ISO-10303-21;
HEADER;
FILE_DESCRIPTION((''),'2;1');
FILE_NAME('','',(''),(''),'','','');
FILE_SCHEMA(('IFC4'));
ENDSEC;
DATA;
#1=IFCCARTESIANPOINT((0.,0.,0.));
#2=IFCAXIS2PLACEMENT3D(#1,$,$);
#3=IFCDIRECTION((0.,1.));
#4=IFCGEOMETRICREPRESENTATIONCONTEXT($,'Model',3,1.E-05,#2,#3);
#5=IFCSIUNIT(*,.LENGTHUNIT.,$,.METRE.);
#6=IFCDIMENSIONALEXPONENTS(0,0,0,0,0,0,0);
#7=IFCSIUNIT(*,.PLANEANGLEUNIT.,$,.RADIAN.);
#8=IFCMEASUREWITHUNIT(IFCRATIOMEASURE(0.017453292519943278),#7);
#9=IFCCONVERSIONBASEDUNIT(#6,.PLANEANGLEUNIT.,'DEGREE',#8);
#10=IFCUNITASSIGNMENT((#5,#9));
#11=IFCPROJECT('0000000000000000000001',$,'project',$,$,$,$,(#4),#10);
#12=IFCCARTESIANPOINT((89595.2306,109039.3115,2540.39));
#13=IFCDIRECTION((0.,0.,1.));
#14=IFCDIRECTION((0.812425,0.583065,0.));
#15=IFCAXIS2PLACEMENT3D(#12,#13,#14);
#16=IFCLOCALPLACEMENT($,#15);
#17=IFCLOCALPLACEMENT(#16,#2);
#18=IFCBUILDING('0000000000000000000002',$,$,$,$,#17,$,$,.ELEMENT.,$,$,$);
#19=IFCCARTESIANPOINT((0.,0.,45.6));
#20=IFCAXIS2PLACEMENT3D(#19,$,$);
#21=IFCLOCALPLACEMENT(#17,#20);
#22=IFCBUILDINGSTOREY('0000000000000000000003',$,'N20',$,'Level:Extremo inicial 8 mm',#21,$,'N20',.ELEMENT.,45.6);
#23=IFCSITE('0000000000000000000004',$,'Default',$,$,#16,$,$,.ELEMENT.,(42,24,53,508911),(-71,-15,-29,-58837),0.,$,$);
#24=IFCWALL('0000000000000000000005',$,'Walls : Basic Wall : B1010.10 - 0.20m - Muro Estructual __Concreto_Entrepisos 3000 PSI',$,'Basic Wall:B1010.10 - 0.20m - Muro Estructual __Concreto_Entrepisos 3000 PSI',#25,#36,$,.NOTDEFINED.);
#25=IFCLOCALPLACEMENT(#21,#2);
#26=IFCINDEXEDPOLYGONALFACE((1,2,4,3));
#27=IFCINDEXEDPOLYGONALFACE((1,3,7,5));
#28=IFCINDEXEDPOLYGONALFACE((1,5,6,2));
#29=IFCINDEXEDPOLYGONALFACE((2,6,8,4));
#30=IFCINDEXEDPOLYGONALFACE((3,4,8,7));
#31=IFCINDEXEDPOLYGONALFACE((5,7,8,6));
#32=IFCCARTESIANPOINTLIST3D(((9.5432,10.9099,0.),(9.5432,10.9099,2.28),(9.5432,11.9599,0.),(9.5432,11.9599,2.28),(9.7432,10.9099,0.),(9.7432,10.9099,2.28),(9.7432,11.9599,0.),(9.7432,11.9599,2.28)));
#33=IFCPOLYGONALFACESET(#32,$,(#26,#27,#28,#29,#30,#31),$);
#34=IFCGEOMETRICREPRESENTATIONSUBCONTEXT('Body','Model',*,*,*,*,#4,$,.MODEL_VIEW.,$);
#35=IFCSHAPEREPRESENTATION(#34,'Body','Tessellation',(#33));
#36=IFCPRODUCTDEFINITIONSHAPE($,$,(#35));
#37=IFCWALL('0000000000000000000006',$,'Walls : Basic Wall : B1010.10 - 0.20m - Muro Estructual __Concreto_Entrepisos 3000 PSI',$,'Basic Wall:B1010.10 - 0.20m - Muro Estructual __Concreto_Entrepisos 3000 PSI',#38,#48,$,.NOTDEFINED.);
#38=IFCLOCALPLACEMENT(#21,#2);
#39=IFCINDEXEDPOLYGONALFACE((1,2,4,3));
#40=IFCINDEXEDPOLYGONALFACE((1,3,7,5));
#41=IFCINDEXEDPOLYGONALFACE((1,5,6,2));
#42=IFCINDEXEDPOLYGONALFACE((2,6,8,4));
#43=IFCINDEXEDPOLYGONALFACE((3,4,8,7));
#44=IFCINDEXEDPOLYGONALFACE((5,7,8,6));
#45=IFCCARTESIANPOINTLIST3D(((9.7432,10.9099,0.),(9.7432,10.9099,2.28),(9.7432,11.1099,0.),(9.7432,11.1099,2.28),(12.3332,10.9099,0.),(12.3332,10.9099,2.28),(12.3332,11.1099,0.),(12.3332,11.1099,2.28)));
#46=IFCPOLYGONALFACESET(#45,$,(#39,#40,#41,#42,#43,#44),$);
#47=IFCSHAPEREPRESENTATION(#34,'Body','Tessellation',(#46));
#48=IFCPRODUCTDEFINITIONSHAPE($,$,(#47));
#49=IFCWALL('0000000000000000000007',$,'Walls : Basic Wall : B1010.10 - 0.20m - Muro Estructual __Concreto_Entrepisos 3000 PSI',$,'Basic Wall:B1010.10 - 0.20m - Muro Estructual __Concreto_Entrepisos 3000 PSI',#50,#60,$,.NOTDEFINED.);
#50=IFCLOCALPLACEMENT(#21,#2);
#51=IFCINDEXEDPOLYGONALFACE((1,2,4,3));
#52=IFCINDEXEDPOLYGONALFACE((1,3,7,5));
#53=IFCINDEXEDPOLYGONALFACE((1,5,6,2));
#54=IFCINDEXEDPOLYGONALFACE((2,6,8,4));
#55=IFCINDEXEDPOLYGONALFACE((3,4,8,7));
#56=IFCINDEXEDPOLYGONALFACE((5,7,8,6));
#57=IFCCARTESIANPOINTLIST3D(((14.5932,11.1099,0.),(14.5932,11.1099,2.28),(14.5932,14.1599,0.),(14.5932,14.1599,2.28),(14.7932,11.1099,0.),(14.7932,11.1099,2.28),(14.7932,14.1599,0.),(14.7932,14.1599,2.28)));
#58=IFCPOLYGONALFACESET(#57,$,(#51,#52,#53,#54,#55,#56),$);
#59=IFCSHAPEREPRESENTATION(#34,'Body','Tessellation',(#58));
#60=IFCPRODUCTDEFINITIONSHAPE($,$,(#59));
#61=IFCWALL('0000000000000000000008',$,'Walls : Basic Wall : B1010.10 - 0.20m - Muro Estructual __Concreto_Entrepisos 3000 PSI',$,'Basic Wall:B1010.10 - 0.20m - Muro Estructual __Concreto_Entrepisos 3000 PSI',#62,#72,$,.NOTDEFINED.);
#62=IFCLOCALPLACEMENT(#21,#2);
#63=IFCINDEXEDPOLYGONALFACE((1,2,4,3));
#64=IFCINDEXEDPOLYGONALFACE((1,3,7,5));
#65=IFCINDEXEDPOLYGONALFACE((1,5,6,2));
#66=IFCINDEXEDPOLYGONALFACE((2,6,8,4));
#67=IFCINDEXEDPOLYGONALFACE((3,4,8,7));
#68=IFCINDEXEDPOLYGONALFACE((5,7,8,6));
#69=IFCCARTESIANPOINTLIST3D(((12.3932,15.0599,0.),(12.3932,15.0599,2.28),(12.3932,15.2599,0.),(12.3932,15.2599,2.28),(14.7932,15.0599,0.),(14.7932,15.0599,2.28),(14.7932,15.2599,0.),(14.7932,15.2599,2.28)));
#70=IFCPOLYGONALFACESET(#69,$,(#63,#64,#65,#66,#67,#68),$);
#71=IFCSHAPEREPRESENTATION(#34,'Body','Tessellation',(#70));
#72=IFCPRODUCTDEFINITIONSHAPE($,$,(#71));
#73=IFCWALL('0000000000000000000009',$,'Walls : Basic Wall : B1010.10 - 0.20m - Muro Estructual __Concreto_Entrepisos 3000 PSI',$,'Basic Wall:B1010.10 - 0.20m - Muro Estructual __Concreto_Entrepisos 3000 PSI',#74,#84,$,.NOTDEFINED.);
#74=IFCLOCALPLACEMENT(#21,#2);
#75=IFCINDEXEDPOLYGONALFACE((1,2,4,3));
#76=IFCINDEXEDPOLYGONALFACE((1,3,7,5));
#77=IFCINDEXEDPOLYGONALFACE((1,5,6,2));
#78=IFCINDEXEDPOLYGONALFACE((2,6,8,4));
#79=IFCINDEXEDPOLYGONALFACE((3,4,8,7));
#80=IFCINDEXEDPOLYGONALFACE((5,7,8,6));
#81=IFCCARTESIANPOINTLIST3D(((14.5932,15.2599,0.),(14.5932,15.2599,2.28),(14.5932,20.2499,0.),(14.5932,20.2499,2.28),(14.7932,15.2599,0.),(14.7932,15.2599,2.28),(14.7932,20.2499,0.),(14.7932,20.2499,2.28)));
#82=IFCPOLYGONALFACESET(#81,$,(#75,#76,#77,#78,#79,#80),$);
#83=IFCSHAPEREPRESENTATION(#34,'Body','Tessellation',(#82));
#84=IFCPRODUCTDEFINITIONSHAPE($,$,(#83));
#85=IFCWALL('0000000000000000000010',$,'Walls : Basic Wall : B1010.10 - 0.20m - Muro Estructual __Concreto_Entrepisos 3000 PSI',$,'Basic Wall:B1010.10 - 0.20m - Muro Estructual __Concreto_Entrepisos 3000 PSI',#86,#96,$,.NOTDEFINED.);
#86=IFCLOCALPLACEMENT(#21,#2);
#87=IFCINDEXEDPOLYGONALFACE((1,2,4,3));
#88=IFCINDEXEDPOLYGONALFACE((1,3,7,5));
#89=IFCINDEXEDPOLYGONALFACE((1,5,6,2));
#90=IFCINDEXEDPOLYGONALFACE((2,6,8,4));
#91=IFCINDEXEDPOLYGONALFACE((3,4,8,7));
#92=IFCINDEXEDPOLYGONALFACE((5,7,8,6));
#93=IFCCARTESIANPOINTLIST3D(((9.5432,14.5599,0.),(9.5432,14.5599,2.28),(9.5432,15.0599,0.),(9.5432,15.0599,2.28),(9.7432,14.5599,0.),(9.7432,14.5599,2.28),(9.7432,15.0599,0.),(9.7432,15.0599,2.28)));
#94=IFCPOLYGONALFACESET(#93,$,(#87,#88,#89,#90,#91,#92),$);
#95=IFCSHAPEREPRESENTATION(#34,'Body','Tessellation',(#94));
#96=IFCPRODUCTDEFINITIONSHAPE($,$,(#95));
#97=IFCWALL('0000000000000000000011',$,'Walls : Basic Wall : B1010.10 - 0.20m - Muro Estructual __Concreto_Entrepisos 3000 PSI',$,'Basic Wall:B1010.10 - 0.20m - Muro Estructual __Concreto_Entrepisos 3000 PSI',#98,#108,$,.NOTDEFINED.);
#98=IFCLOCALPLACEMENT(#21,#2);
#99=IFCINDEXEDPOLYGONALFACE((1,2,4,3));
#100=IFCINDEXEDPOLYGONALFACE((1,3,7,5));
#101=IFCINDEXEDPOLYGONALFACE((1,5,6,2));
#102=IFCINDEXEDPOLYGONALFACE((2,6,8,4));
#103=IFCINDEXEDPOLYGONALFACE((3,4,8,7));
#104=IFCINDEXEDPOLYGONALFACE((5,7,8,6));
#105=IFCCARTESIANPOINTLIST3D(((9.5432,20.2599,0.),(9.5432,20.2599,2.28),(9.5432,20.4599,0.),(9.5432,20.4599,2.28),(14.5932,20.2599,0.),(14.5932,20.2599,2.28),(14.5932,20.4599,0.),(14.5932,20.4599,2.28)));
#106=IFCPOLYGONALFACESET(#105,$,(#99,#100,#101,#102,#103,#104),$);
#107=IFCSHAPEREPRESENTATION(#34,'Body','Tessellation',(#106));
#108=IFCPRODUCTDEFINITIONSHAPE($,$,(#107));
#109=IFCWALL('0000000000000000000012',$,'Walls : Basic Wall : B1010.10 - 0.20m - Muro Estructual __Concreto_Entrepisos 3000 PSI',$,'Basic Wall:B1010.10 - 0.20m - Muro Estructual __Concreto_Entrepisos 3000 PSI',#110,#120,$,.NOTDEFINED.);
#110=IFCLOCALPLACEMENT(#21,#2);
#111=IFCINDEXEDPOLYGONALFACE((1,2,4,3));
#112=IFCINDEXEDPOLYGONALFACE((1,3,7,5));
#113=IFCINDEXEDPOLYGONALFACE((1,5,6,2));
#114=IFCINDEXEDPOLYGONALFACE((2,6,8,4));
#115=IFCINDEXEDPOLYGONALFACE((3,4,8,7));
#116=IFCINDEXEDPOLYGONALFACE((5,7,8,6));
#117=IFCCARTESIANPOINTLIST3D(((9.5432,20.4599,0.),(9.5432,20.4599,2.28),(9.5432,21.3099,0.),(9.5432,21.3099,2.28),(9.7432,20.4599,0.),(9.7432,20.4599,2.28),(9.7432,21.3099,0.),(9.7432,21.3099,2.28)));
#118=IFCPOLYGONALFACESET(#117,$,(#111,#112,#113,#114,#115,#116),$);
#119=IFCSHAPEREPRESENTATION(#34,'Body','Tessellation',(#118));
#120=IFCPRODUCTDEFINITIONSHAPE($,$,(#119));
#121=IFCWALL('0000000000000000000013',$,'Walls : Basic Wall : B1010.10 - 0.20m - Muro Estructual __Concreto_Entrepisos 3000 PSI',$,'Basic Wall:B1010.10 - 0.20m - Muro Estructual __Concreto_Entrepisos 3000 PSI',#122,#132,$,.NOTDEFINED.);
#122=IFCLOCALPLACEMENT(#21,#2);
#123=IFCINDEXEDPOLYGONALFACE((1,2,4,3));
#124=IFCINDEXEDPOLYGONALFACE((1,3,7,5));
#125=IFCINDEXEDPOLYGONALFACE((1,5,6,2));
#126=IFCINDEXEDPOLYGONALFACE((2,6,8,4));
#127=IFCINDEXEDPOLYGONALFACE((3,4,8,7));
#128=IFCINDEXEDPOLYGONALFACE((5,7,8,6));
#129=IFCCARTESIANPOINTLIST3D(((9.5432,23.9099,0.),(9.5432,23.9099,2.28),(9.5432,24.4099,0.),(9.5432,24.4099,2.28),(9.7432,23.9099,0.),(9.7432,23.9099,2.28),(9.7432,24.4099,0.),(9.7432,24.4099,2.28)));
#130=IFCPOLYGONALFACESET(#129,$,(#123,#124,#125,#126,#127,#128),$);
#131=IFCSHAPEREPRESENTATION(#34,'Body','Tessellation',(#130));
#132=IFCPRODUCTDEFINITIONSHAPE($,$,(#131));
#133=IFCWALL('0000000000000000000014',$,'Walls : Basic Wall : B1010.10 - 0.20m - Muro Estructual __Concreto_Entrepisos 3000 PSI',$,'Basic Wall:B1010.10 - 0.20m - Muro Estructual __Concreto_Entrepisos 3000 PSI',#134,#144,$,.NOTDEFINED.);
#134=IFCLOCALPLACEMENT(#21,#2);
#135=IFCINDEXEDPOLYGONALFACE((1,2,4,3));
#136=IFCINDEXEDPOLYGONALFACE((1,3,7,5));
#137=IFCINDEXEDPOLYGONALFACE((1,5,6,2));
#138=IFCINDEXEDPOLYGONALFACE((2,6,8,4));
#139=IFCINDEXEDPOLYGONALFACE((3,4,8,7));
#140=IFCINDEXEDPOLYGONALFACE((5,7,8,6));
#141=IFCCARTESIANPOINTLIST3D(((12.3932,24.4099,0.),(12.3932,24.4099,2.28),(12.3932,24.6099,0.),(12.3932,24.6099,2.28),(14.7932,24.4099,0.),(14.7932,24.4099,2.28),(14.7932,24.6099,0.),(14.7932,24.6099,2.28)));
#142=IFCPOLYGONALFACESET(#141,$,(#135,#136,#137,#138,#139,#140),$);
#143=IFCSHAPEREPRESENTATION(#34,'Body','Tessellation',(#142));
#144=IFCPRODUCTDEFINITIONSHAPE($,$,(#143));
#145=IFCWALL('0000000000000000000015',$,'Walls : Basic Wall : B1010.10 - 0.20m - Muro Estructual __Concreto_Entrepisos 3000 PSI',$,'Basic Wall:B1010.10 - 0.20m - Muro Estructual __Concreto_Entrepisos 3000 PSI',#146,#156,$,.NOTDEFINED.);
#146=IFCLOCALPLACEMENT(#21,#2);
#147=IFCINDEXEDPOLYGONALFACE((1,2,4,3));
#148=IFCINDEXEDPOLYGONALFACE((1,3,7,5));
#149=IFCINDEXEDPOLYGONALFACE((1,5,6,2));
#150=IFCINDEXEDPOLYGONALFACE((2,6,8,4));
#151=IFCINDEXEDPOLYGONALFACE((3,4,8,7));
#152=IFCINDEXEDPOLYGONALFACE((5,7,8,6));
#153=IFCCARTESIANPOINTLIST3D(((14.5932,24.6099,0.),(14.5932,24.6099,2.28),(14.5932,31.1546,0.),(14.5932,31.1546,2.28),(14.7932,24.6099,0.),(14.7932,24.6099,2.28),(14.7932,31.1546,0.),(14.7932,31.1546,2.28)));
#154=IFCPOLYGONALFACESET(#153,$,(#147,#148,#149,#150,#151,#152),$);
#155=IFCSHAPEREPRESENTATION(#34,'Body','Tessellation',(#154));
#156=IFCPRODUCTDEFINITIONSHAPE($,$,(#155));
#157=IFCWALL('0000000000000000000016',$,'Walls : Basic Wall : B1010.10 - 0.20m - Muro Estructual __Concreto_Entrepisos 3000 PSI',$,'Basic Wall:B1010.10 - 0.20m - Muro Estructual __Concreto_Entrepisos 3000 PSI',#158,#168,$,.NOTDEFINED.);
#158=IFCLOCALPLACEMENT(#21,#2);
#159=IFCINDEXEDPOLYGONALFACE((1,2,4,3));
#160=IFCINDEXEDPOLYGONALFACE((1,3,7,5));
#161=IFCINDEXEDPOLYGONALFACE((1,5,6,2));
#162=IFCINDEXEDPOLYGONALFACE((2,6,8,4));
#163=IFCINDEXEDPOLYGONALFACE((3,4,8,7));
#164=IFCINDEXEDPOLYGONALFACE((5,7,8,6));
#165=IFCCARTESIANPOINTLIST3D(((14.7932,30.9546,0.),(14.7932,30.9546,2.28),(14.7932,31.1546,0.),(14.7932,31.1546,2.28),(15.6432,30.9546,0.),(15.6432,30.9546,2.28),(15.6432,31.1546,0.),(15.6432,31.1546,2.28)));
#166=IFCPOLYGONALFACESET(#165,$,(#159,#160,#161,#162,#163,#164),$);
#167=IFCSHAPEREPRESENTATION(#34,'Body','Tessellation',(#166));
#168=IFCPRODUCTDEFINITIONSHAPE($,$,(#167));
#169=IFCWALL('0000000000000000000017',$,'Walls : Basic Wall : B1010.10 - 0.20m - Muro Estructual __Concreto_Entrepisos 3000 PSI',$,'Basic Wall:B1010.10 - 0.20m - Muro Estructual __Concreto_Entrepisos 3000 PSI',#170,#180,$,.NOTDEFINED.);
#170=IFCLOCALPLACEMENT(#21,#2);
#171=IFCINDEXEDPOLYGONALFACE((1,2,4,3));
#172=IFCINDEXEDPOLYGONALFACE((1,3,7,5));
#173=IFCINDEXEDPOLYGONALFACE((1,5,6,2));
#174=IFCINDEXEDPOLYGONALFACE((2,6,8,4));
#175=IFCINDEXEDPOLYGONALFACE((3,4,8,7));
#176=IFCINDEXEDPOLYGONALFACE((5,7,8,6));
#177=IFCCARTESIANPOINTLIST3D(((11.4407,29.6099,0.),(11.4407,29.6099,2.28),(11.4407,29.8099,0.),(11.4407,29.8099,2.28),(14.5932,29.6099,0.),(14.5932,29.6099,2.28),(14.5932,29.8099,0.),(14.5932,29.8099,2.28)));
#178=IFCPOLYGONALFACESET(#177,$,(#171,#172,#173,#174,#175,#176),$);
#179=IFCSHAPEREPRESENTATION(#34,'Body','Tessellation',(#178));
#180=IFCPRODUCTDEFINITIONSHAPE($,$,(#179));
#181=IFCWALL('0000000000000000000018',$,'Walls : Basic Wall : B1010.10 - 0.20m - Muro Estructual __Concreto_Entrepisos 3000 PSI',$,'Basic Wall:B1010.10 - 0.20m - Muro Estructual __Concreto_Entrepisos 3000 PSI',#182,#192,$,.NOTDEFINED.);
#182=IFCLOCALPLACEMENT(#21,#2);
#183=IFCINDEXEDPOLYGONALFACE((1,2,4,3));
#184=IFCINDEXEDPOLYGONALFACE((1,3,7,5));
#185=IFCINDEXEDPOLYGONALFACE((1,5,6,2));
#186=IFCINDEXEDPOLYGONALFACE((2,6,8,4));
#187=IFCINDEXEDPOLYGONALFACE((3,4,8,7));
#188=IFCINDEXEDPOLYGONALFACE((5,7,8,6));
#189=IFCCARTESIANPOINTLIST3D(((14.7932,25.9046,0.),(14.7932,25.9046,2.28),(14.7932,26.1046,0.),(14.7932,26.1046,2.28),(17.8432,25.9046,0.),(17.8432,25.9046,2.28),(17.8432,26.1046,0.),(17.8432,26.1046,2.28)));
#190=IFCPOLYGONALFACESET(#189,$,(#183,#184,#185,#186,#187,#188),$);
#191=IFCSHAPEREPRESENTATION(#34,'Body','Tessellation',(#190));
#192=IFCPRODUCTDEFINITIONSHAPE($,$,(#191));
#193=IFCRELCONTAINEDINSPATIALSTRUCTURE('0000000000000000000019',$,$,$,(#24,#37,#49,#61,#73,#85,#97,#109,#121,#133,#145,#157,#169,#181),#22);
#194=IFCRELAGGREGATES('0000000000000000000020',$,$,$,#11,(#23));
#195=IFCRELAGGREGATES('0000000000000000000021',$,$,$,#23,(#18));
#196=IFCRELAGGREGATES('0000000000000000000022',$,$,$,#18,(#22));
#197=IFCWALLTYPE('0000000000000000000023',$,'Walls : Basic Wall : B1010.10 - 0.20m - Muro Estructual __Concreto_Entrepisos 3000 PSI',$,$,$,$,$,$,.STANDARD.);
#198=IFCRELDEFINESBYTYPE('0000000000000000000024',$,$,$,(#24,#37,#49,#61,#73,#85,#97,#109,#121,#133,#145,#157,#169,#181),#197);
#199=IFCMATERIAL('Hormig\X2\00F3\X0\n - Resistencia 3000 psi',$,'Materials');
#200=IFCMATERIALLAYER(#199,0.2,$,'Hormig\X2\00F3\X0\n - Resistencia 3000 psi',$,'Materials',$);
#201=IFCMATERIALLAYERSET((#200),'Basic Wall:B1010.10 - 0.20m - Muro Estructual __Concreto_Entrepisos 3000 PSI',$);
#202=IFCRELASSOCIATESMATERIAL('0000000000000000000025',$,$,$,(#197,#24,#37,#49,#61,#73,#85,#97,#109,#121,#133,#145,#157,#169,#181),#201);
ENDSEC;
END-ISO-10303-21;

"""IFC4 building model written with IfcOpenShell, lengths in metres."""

from ifc_helpers import new_model, entity, si_unit, converted_unit, direction, frame, frame_2d, origin, place, context, subcontext, project, spatial, rectangle, extrude, material, layer, layer_set, layer_usage, type_object, element, save


model = new_model("IFC4")

# Units and contexts
model_context = context("Model", 3, precision=1e-05, world=origin(), true_north=direction((0.0, 1.0)))
body_context = subcontext(model_context, "Body", "Model", "MODEL_VIEW")
ifc_project = project(units=[si_unit("LENGTHUNIT", "METRE"), converted_unit("PLANEANGLEUNIT", "DEGREE", entity("IfcRatioMeasure", 0.017453292519943278), si_unit("PLANEANGLEUNIT", "RADIAN"), dimensions=[0, 0, 0, 0, 0, 0, 0])], contexts=[model_context])

# Site, building, storey
site_placement = place(None, frame((89595.2306, 109039.3115, 2540.39), z_axis=(0.0, 0.0, 1.0), x_axis=(0.812425, 0.583065, 0.0)))
site = spatial("IfcSite", under=ifc_project, at=site_placement, Name="Default", CompositionType="ELEMENT", RefLatitude=(42, 24, 53, 508911), RefLongitude=(-71, -15, -29, -58837), RefElevation=0.0)
building_placement = place(site_placement, origin())
building = spatial("IfcBuilding", under=site, at=building_placement, CompositionType="ELEMENT")
storey_placement = place(building_placement, frame((0.0, 0.0, 45.6)))
storey = spatial("IfcBuildingStorey", under=building, at=storey_placement, Name="N20", ObjectType="Level:Extremo inicial 8 mm", LongName="N20", CompositionType="ELEMENT", Elevation=45.6)

# Walls
ifc_material = material(Name="Hormigón - Resistencia 3000 psi", Category="Materials")
ifc_layer_1 = layer(ifc_material, 0.2, Name="Hormigón - Resistencia 3000 psi", Category="Materials")
ifc_layer_set_1 = layer_set([ifc_layer_1], Name="Basic Wall:B1010.10 - 0.20m - Muro Estructual __Concreto_Entrepisos 3000 PSI")
ifc_layer_usage_1 = layer_usage(ifc_layer_set_1, "AXIS2", "POSITIVE", -0.1)
wall_type_1 = type_object("IfcWallType", Name="Walls : Basic Wall : B1010.10 - 0.20m - Muro Estructual __Concreto_Entrepisos 3000 PSI", PredefinedType="STANDARD", material=ifc_layer_set_1)
wall_1_placement = place(storey_placement, frame((9.6432, 11.9599, 0.0), z_axis=(0.0, 0.0, 1.0), x_axis=(0.0, -1.0, 0.0)))
element("IfcWall", 1, at=wall_1_placement, inside=storey, type_object=wall_type_1, material=ifc_layer_usage_1, Name="Walls : Basic Wall : B1010.10 - 0.20m - Muro Estructual __Concreto_Entrepisos 3000 PSI", ObjectType="Basic Wall:B1010.10 - 0.20m - Muro Estructual __Concreto_Entrepisos 3000 PSI", PredefinedType="NOTDEFINED", context=body_context, shape_type="SweptSolid", body=[
    extrude(rectangle(XDim=1.05, YDim=0.2, at=frame_2d((0.525, 0.0), x_axis=(-1.0, 0.0))), origin(), (0.0, 0.0, 1.0), 2.28),
])
ifc_layer_usage_2 = layer_usage(ifc_layer_set_1, "AXIS2", "POSITIVE", -0.1)
wall_2_placement = place(storey_placement, frame((9.7432, 11.0099, 0.0)))
element("IfcWall", 2, at=wall_2_placement, inside=storey, type_object=wall_type_1, material=ifc_layer_usage_2, Name="Walls : Basic Wall : B1010.10 - 0.20m - Muro Estructual __Concreto_Entrepisos 3000 PSI", ObjectType="Basic Wall:B1010.10 - 0.20m - Muro Estructual __Concreto_Entrepisos 3000 PSI", PredefinedType="NOTDEFINED", context=body_context, shape_type="SweptSolid", body=[
    extrude(rectangle(XDim=2.59, YDim=0.2, at=frame_2d((1.295, 0.0), x_axis=(-1.0, 0.0))), origin(), (0.0, 0.0, 1.0), 2.28),
])
ifc_layer_usage_3 = layer_usage(ifc_layer_set_1, "AXIS2", "POSITIVE", -0.1)
wall_3_placement = place(storey_placement, frame((14.6932, 14.1599, 0.0), z_axis=(0.0, 0.0, 1.0), x_axis=(0.0, -1.0, 0.0)))
element("IfcWall", 3, at=wall_3_placement, inside=storey, type_object=wall_type_1, material=ifc_layer_usage_3, Name="Walls : Basic Wall : B1010.10 - 0.20m - Muro Estructual __Concreto_Entrepisos 3000 PSI", ObjectType="Basic Wall:B1010.10 - 0.20m - Muro Estructual __Concreto_Entrepisos 3000 PSI", PredefinedType="NOTDEFINED", context=body_context, shape_type="SweptSolid", body=[
    extrude(rectangle(XDim=3.05, YDim=0.2, at=frame_2d((1.525, 0.0), x_axis=(-1.0, 0.0))), origin(), (0.0, 0.0, 1.0), 2.28),
])
ifc_layer_usage_4 = layer_usage(ifc_layer_set_1, "AXIS2", "POSITIVE", -0.1)
wall_4_placement = place(storey_placement, frame((12.3932, 15.1599, 0.0)))
element("IfcWall", 4, at=wall_4_placement, inside=storey, type_object=wall_type_1, material=ifc_layer_usage_4, Name="Walls : Basic Wall : B1010.10 - 0.20m - Muro Estructual __Concreto_Entrepisos 3000 PSI", ObjectType="Basic Wall:B1010.10 - 0.20m - Muro Estructual __Concreto_Entrepisos 3000 PSI", PredefinedType="NOTDEFINED", context=body_context, shape_type="SweptSolid", body=[
    extrude(rectangle(XDim=2.4, YDim=0.2, at=frame_2d((1.2, 0.0), x_axis=(-1.0, 0.0))), origin(), (0.0, 0.0, 1.0), 2.28),
])
ifc_layer_usage_5 = layer_usage(ifc_layer_set_1, "AXIS2", "POSITIVE", -0.1)
wall_5_placement = place(storey_placement, frame((14.6932, 15.2599, 0.0), z_axis=(0.0, 0.0, 1.0), x_axis=(0.0, 1.0, 0.0)))
element("IfcWall", 5, at=wall_5_placement, inside=storey, type_object=wall_type_1, material=ifc_layer_usage_5, Name="Walls : Basic Wall : B1010.10 - 0.20m - Muro Estructual __Concreto_Entrepisos 3000 PSI", ObjectType="Basic Wall:B1010.10 - 0.20m - Muro Estructual __Concreto_Entrepisos 3000 PSI", PredefinedType="NOTDEFINED", context=body_context, shape_type="SweptSolid", body=[
    extrude(rectangle(XDim=4.99, YDim=0.2, at=frame_2d((2.495, 0.0), x_axis=(-1.0, 0.0))), origin(), (0.0, 0.0, 1.0), 2.28),
])
ifc_layer_usage_6 = layer_usage(ifc_layer_set_1, "AXIS2", "POSITIVE", -0.1)
wall_6_placement = place(storey_placement, frame((9.6432, 14.5599, 0.0), z_axis=(0.0, 0.0, 1.0), x_axis=(0.0, 1.0, 0.0)))
element("IfcWall", 6, at=wall_6_placement, inside=storey, type_object=wall_type_1, material=ifc_layer_usage_6, Name="Walls : Basic Wall : B1010.10 - 0.20m - Muro Estructual __Concreto_Entrepisos 3000 PSI", ObjectType="Basic Wall:B1010.10 - 0.20m - Muro Estructual __Concreto_Entrepisos 3000 PSI", PredefinedType="NOTDEFINED", context=body_context, shape_type="SweptSolid", body=[
    extrude(rectangle(XDim=0.5, YDim=0.2, at=frame_2d((0.25, 0.0), x_axis=(-1.0, 0.0))), origin(), (0.0, 0.0, 1.0), 2.28),
])
ifc_layer_usage_7 = layer_usage(ifc_layer_set_1, "AXIS2", "POSITIVE", -0.1)
wall_7_placement = place(storey_placement, frame((14.5932, 20.3599, 0.0), z_axis=(0.0, 0.0, 1.0), x_axis=(-1.0, 0.0, 0.0)))
element("IfcWall", 7, at=wall_7_placement, inside=storey, type_object=wall_type_1, material=ifc_layer_usage_7, Name="Walls : Basic Wall : B1010.10 - 0.20m - Muro Estructual __Concreto_Entrepisos 3000 PSI", ObjectType="Basic Wall:B1010.10 - 0.20m - Muro Estructual __Concreto_Entrepisos 3000 PSI", PredefinedType="NOTDEFINED", context=body_context, shape_type="SweptSolid", body=[
    extrude(rectangle(XDim=5.05, YDim=0.2, at=frame_2d((2.525, 0.0), x_axis=(-1.0, 0.0))), origin(), (0.0, 0.0, 1.0), 2.28),
])
ifc_layer_usage_8 = layer_usage(ifc_layer_set_1, "AXIS2", "NEGATIVE", 0.1)
wall_8_placement = place(storey_placement, frame((9.6432, 20.4599, 0.0), z_axis=(0.0, 0.0, 1.0), x_axis=(0.0, 1.0, 0.0)))
element("IfcWall", 8, at=wall_8_placement, inside=storey, type_object=wall_type_1, material=ifc_layer_usage_8, Name="Walls : Basic Wall : B1010.10 - 0.20m - Muro Estructual __Concreto_Entrepisos 3000 PSI", ObjectType="Basic Wall:B1010.10 - 0.20m - Muro Estructual __Concreto_Entrepisos 3000 PSI", PredefinedType="NOTDEFINED", context=body_context, shape_type="SweptSolid", body=[
    extrude(rectangle(XDim=0.85, YDim=0.2, at=frame_2d((0.425, 0.0), x_axis=(-1.0, 0.0))), origin(), (0.0, 0.0, 1.0), 2.28),
])
ifc_layer_usage_9 = layer_usage(ifc_layer_set_1, "AXIS2", "NEGATIVE", 0.1)
wall_9_placement = place(storey_placement, frame((9.6432, 23.9099, 0.0), z_axis=(0.0, 0.0, 1.0), x_axis=(0.0, 1.0, 0.0)))
element("IfcWall", 9, at=wall_9_placement, inside=storey, type_object=wall_type_1, material=ifc_layer_usage_9, Name="Walls : Basic Wall : B1010.10 - 0.20m - Muro Estructual __Concreto_Entrepisos 3000 PSI", ObjectType="Basic Wall:B1010.10 - 0.20m - Muro Estructual __Concreto_Entrepisos 3000 PSI", PredefinedType="NOTDEFINED", context=body_context, shape_type="SweptSolid", body=[
    extrude(rectangle(XDim=0.5, YDim=0.2, at=frame_2d((0.25, 0.0), x_axis=(-1.0, 0.0))), origin(), (0.0, 0.0, 1.0), 2.28),
])
ifc_layer_usage_10 = layer_usage(ifc_layer_set_1, "AXIS2", "NEGATIVE", 0.1)
wall_10_placement = place(storey_placement, frame((12.3932, 24.5099, 0.0)))
element("IfcWall", 10, at=wall_10_placement, inside=storey, type_object=wall_type_1, material=ifc_layer_usage_10, Name="Walls : Basic Wall : B1010.10 - 0.20m - Muro Estructual __Concreto_Entrepisos 3000 PSI", ObjectType="Basic Wall:B1010.10 - 0.20m - Muro Estructual __Concreto_Entrepisos 3000 PSI", PredefinedType="NOTDEFINED", context=body_context, shape_type="SweptSolid", body=[
    extrude(rectangle(XDim=2.4, YDim=0.2, at=frame_2d((1.2, 0.0), x_axis=(-1.0, 0.0))), origin(), (0.0, 0.0, 1.0), 2.28),
])
ifc_layer_usage_11 = layer_usage(ifc_layer_set_1, "AXIS2", "NEGATIVE", 0.1)
wall_11_placement = place(storey_placement, frame((14.6932, 24.6099, 0.0), z_axis=(0.0, 0.0, 1.0), x_axis=(0.0, 1.0, 0.0)))
element("IfcWall", 11, at=wall_11_placement, inside=storey, type_object=wall_type_1, material=ifc_layer_usage_11, Name="Walls : Basic Wall : B1010.10 - 0.20m - Muro Estructual __Concreto_Entrepisos 3000 PSI", ObjectType="Basic Wall:B1010.10 - 0.20m - Muro Estructual __Concreto_Entrepisos 3000 PSI", PredefinedType="NOTDEFINED", context=body_context, shape_type="SweptSolid", body=[
    extrude(rectangle(XDim=6.5447, YDim=0.2, at=frame_2d((3.2724, 0.0), x_axis=(-1.0, 0.0))), origin(), (0.0, 0.0, 1.0), 2.28),
])
ifc_layer_usage_12 = layer_usage(ifc_layer_set_1, "AXIS2", "NEGATIVE", 0.1)
wall_12_placement = place(storey_placement, frame((15.6432, 31.0546, 0.0), z_axis=(0.0, 0.0, 1.0), x_axis=(-1.0, 0.0, 0.0)))
element("IfcWall", 12, at=wall_12_placement, inside=storey, type_object=wall_type_1, material=ifc_layer_usage_12, Name="Walls : Basic Wall : B1010.10 - 0.20m - Muro Estructual __Concreto_Entrepisos 3000 PSI", ObjectType="Basic Wall:B1010.10 - 0.20m - Muro Estructual __Concreto_Entrepisos 3000 PSI", PredefinedType="NOTDEFINED", context=body_context, shape_type="SweptSolid", body=[
    extrude(rectangle(XDim=0.85, YDim=0.2, at=frame_2d((0.425, 0.0), x_axis=(-1.0, 0.0))), origin(), (0.0, 0.0, 1.0), 2.28),
])
ifc_layer_usage_13 = layer_usage(ifc_layer_set_1, "AXIS2", "NEGATIVE", 0.1)
wall_13_placement = place(storey_placement, frame((11.4407, 29.7099, 0.0)))
element("IfcWall", 13, at=wall_13_placement, inside=storey, type_object=wall_type_1, material=ifc_layer_usage_13, Name="Walls : Basic Wall : B1010.10 - 0.20m - Muro Estructual __Concreto_Entrepisos 3000 PSI", ObjectType="Basic Wall:B1010.10 - 0.20m - Muro Estructual __Concreto_Entrepisos 3000 PSI", PredefinedType="NOTDEFINED", context=body_context, shape_type="SweptSolid", body=[
    extrude(rectangle(XDim=3.1525, YDim=0.2, at=frame_2d((1.5763, 0.0), x_axis=(-1.0, 0.0))), origin(), (0.0, 0.0, 1.0), 2.28),
])
ifc_layer_usage_14 = layer_usage(ifc_layer_set_1, "AXIS2", "NEGATIVE", 0.1)
wall_14_placement = place(storey_placement, frame((17.8432, 26.0046, 0.0), z_axis=(0.0, 0.0, 1.0), x_axis=(-1.0, 0.0, 0.0)))
element("IfcWall", 14, at=wall_14_placement, inside=storey, type_object=wall_type_1, material=ifc_layer_usage_14, Name="Walls : Basic Wall : B1010.10 - 0.20m - Muro Estructual __Concreto_Entrepisos 3000 PSI", ObjectType="Basic Wall:B1010.10 - 0.20m - Muro Estructual __Concreto_Entrepisos 3000 PSI", PredefinedType="NOTDEFINED", context=body_context, shape_type="SweptSolid", body=[
    extrude(rectangle(XDim=3.05, YDim=0.2, at=frame_2d((1.525, 0.0), x_axis=(-1.0, 0.0))), origin(), (0.0, 0.0, 1.0), 2.28),
])

save(model, "model.ifc")
